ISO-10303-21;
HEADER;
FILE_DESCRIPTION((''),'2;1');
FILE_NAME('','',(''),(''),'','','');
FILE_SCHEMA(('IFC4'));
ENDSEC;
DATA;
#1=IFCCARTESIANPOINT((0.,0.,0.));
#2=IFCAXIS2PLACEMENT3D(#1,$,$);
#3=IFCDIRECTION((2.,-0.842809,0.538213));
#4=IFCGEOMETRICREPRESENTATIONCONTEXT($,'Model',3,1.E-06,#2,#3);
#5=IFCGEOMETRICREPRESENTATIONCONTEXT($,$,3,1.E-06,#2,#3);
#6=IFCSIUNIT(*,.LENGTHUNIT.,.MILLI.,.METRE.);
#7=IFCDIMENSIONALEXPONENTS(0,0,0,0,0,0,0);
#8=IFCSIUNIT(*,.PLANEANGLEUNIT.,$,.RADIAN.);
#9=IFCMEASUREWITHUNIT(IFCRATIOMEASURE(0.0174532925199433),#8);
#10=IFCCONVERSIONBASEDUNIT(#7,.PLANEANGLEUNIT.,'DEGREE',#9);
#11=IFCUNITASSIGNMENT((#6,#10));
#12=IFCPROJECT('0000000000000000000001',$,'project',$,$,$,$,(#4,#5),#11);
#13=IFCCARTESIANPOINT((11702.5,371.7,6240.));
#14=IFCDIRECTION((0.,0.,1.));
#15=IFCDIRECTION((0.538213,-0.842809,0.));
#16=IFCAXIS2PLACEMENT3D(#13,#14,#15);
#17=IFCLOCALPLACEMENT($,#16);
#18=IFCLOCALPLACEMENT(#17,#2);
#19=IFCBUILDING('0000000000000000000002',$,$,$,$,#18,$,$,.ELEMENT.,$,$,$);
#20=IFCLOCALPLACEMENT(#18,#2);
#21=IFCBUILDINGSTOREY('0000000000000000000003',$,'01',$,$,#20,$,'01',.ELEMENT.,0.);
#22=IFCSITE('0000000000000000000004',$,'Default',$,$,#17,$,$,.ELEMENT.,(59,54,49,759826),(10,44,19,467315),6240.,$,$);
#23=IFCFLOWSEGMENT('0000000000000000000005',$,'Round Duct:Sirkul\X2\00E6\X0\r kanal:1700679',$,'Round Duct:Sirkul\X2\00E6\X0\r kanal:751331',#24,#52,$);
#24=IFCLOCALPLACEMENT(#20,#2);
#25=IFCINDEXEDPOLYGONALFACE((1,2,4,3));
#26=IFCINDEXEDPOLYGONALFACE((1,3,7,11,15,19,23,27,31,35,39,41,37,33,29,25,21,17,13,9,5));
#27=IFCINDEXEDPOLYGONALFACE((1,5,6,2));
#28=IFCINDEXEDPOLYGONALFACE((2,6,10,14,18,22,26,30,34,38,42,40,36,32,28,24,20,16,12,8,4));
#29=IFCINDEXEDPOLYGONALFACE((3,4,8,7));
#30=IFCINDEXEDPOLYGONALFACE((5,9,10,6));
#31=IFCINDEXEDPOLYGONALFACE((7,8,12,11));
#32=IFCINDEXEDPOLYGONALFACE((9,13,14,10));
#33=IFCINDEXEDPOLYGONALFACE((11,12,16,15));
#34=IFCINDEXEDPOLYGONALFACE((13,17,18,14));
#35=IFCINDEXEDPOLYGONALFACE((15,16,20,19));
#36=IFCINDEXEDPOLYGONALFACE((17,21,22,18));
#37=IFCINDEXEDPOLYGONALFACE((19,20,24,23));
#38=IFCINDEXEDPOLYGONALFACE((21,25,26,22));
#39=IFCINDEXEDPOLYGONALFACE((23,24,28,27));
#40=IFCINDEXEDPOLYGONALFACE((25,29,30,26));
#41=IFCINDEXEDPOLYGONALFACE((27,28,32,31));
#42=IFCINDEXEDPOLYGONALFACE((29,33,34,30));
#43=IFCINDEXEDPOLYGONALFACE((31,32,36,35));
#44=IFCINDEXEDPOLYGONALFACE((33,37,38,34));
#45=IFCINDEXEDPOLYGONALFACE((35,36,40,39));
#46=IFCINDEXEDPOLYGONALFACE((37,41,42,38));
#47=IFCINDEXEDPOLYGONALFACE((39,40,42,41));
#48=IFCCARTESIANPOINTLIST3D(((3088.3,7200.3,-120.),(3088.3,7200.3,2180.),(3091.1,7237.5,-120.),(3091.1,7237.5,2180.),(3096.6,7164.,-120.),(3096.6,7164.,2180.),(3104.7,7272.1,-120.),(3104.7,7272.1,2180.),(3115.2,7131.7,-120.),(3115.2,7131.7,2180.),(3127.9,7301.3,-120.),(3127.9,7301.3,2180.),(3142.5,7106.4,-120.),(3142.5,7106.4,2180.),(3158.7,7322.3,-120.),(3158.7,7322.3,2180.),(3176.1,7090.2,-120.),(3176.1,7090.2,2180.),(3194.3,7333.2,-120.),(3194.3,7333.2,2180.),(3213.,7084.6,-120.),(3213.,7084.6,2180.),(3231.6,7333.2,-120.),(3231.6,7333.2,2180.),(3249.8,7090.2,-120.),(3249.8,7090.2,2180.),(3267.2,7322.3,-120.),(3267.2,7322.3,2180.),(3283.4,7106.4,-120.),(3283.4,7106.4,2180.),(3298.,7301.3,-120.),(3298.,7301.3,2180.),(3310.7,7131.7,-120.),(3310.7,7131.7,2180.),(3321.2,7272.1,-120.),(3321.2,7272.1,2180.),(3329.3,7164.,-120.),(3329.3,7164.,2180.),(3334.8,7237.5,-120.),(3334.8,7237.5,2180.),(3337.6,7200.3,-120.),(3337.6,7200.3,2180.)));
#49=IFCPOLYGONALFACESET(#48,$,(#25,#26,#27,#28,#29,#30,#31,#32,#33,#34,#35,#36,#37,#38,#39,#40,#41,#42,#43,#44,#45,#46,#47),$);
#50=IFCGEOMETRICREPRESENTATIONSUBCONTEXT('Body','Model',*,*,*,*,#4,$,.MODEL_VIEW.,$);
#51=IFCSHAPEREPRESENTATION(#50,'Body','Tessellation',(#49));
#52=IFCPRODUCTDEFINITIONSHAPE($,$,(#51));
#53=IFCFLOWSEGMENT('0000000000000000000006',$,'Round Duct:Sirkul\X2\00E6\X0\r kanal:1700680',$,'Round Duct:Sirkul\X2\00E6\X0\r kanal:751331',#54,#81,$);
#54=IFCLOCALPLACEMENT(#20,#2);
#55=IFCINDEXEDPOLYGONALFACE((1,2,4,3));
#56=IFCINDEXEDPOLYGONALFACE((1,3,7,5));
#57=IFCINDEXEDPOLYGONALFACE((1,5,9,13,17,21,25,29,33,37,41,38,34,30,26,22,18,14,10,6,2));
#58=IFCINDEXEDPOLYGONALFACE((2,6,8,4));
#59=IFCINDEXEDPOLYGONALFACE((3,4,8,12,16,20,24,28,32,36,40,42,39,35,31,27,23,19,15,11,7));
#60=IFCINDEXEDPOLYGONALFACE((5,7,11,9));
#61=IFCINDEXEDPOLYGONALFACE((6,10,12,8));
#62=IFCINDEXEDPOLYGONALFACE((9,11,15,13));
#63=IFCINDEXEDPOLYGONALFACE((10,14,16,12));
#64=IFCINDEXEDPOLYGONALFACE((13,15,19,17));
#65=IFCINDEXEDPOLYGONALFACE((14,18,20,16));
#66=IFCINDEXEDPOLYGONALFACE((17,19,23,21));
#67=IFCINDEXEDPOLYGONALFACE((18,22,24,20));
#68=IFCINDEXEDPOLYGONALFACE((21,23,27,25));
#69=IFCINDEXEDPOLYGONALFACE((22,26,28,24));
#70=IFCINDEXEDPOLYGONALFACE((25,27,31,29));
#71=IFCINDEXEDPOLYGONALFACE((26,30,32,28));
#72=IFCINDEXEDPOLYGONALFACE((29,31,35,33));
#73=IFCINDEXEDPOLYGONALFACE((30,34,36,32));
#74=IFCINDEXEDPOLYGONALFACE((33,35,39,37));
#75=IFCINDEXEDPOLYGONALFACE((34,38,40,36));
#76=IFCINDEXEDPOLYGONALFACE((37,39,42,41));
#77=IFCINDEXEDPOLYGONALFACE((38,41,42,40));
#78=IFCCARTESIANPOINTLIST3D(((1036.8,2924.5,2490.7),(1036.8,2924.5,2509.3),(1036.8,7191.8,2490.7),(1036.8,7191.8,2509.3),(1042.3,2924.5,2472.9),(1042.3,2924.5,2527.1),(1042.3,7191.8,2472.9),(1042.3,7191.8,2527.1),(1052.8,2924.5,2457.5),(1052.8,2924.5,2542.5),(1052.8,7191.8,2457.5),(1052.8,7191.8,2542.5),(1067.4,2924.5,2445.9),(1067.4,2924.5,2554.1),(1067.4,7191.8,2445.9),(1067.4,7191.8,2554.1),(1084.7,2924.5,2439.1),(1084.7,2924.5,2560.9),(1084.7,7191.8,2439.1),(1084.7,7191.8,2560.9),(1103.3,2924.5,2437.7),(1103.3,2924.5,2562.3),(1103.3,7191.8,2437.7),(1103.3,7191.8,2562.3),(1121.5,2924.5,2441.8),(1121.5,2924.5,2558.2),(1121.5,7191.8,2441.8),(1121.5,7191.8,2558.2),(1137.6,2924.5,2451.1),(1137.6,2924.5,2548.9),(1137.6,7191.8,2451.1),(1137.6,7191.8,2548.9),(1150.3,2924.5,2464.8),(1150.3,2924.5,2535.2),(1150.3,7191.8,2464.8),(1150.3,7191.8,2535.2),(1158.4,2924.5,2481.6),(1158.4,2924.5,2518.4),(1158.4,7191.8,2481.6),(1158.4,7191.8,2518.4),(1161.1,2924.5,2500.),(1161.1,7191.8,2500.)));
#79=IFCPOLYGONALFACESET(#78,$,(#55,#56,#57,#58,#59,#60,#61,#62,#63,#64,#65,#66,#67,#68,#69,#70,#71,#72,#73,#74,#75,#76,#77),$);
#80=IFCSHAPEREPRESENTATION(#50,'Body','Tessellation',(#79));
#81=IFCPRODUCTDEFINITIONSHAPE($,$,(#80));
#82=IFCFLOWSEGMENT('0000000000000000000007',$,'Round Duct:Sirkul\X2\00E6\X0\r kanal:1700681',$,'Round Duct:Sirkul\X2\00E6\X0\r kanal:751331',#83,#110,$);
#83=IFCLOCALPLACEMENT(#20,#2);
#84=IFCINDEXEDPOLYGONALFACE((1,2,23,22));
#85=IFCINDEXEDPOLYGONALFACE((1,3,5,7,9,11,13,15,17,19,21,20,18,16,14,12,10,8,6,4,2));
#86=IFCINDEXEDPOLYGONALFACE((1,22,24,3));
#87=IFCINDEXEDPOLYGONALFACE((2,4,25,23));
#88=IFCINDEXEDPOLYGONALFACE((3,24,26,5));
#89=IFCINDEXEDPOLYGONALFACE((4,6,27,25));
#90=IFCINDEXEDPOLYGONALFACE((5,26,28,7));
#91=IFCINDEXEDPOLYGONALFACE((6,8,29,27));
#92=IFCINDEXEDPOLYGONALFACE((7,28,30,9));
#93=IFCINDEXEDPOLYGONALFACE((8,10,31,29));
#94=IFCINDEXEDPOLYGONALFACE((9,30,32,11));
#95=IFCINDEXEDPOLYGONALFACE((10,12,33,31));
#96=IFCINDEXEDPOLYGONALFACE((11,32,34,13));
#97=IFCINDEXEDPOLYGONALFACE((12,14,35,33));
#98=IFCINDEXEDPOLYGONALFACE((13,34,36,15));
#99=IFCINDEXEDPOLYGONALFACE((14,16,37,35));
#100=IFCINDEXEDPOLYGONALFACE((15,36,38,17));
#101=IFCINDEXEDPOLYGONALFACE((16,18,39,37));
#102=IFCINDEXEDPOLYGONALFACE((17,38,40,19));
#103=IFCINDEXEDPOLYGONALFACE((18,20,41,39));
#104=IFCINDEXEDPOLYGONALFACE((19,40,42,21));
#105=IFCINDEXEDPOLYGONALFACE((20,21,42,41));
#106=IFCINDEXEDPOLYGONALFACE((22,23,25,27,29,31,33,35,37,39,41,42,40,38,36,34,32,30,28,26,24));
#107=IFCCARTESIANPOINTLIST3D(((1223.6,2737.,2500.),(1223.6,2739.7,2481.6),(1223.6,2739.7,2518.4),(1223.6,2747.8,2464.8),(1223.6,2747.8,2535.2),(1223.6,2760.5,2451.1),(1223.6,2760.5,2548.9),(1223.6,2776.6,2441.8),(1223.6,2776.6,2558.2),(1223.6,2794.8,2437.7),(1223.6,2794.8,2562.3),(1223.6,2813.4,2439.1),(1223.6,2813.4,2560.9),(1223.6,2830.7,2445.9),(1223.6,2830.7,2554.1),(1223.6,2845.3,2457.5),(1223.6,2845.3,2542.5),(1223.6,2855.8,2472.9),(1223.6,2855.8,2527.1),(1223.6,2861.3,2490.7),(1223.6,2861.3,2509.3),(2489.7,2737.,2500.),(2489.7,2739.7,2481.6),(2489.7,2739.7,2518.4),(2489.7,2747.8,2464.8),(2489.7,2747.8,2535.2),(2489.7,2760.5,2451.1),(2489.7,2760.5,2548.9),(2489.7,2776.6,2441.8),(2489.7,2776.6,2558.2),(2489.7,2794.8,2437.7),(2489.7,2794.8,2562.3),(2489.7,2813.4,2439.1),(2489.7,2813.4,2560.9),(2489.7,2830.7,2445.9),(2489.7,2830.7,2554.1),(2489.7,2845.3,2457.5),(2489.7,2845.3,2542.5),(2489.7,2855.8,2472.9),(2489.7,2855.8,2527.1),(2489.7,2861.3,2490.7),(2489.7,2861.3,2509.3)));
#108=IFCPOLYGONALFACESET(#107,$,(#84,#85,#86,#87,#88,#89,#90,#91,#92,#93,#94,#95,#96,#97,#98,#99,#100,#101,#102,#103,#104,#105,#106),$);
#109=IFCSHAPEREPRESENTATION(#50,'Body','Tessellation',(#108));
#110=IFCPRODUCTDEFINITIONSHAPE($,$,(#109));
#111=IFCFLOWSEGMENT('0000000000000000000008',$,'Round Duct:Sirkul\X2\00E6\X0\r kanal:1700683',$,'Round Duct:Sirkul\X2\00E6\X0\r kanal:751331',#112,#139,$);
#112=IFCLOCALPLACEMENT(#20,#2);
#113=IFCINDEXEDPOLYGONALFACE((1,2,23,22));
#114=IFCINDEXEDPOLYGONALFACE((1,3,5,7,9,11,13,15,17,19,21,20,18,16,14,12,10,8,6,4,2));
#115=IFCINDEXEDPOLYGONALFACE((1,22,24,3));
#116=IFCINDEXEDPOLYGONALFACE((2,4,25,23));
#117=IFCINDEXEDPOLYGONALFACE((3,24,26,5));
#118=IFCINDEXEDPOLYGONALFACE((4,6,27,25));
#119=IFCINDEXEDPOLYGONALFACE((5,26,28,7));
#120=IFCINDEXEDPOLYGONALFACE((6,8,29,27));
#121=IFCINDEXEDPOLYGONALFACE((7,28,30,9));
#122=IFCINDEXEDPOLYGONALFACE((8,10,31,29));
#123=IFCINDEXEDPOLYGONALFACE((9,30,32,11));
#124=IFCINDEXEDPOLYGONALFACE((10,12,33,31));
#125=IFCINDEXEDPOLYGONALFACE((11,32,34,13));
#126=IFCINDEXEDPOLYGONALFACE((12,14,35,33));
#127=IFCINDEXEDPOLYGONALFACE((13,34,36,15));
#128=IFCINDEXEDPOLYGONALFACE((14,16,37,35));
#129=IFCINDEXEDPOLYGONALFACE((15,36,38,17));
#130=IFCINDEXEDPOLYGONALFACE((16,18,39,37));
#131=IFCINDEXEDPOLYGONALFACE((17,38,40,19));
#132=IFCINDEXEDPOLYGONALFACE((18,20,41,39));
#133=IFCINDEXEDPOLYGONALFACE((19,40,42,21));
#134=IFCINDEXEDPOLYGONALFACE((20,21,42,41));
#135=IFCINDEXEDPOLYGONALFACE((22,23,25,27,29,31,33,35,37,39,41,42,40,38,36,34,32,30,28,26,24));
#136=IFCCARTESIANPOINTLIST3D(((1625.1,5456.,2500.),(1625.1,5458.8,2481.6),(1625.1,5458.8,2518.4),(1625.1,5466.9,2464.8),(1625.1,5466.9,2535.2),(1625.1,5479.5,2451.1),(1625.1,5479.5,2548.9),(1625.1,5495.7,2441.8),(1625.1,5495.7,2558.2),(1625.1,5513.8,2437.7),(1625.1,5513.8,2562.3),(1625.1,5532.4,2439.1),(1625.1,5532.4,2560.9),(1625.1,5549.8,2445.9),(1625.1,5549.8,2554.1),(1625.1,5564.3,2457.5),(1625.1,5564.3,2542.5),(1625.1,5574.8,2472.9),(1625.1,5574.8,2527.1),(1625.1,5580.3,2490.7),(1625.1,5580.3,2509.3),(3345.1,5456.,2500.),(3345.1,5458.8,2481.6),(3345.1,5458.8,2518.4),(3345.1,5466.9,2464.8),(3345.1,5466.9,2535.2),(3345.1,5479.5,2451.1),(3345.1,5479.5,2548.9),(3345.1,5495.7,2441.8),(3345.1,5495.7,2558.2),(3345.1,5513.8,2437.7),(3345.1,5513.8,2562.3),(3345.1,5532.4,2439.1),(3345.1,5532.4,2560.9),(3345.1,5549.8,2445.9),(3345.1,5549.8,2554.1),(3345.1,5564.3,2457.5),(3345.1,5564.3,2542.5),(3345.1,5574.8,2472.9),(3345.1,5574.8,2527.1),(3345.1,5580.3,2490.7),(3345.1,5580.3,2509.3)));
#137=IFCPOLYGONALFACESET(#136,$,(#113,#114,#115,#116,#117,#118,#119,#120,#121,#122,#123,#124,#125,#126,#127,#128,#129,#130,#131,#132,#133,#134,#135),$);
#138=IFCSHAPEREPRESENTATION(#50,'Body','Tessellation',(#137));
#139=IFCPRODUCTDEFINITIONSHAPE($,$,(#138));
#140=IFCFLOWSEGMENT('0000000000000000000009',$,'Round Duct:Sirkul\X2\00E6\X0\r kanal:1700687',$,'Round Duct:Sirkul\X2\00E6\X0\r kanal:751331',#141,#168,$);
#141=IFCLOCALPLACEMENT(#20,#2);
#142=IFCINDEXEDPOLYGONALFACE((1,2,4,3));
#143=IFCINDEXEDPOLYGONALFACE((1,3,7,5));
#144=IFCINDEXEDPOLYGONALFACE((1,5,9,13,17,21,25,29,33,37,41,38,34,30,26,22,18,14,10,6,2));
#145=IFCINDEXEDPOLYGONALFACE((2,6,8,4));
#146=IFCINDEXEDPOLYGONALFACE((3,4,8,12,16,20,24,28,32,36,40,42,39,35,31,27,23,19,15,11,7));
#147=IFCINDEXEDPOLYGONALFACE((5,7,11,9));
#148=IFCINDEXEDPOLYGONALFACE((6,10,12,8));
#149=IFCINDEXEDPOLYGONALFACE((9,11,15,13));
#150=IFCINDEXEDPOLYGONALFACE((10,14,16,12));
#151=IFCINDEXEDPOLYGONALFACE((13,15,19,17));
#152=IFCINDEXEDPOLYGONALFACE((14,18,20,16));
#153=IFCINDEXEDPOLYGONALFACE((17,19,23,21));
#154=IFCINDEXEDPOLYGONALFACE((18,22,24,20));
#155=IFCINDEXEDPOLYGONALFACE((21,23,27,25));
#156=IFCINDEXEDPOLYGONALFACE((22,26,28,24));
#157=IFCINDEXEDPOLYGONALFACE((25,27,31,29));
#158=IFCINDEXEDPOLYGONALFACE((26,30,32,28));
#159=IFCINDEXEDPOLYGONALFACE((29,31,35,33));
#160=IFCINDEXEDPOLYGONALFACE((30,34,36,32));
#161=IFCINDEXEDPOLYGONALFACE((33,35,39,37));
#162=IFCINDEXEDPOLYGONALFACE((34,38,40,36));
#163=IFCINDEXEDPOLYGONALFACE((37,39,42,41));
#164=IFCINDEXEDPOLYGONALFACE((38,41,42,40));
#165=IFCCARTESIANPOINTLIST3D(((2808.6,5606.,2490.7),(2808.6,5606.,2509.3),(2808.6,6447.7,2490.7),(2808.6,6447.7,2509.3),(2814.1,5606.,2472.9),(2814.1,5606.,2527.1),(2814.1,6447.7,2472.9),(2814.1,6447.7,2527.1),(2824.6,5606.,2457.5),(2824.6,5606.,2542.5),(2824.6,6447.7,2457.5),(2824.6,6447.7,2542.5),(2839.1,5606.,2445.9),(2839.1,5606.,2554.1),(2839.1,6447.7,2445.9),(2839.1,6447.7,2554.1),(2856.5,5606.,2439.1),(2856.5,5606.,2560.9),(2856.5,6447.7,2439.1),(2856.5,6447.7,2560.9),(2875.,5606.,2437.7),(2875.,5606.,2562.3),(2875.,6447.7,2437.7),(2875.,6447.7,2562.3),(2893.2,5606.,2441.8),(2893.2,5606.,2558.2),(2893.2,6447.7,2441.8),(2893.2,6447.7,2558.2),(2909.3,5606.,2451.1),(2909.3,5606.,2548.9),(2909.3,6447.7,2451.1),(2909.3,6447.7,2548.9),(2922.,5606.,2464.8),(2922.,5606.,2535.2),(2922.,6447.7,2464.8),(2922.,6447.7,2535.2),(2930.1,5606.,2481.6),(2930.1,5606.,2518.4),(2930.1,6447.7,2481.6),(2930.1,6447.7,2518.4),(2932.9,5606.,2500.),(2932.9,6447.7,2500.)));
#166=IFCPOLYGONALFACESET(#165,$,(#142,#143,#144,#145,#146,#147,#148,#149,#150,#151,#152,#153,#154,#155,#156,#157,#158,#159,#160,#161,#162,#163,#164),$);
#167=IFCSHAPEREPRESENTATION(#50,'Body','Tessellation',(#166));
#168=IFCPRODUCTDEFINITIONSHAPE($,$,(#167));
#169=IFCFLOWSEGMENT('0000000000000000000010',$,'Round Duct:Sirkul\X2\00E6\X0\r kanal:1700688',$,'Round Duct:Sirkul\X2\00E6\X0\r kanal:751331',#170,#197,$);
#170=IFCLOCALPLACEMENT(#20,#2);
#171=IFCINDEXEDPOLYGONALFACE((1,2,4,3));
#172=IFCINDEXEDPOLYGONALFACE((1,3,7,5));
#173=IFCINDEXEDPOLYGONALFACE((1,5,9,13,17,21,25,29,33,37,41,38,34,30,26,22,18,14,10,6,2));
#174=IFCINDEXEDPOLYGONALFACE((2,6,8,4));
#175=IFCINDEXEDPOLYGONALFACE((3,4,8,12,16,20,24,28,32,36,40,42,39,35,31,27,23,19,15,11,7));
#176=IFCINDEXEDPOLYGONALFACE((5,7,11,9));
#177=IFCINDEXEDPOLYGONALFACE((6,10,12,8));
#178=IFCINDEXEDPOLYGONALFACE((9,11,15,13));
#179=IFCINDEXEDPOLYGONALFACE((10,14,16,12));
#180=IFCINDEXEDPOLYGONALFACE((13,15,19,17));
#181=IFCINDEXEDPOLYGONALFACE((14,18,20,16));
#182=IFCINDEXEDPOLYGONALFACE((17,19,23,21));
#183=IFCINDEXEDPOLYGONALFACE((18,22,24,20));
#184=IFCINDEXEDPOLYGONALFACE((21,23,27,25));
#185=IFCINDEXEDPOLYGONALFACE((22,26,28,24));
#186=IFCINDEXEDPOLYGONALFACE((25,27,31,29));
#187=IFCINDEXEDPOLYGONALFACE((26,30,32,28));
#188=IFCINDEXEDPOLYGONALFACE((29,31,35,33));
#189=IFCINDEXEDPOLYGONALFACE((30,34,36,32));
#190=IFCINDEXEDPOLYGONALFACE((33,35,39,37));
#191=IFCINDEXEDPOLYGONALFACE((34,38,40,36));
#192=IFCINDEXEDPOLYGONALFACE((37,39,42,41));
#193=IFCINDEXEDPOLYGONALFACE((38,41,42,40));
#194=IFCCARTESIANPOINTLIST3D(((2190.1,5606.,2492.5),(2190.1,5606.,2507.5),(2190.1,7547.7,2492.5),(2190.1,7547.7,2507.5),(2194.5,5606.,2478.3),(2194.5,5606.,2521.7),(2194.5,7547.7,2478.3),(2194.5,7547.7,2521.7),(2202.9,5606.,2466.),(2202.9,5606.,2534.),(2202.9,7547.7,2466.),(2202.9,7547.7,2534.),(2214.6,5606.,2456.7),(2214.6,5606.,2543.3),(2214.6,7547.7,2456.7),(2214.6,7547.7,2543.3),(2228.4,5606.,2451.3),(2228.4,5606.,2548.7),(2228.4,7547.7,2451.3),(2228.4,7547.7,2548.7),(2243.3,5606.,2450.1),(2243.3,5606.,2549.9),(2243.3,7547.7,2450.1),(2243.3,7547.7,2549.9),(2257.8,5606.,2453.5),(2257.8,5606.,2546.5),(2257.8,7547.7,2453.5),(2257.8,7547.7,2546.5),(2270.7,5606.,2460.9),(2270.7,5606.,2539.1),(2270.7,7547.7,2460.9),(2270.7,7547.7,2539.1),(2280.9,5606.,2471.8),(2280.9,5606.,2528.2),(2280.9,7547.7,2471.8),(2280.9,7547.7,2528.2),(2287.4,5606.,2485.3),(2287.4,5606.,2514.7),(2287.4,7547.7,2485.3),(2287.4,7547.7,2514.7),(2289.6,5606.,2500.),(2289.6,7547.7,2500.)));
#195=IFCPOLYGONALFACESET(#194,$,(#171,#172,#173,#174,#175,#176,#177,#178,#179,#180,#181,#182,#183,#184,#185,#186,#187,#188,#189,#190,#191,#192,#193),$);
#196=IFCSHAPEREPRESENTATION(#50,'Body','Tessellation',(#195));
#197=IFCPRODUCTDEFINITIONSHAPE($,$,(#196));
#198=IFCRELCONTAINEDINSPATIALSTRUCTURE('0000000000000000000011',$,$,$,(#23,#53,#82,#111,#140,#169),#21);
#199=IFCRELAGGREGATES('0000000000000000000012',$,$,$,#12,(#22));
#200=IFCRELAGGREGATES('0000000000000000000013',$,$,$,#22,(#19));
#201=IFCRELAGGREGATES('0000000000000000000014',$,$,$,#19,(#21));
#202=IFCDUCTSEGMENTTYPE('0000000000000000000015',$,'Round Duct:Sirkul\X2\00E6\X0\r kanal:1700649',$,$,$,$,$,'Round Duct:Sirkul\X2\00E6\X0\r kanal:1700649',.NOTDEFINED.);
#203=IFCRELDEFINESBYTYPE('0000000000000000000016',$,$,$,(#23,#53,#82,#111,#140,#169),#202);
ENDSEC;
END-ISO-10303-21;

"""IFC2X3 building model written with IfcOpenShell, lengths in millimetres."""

from ifc_helpers import new_model, entity, si_unit, converted_unit, direction, frame, frame_2d, origin, origin_2d_with_axis, place, context, subcontext, project, spatial, circle, extrude, type_object, element, save


model = new_model("IFC2X3")

# Units and contexts
model_context = context("Model", 3, precision=1e-06, world=origin(), true_north=direction((2.0, -0.842809, 0.538213)))
context_of_model = context(None, 3, precision=1e-06, world=origin(), true_north=direction((2.0, -0.842809, 0.538213)))
body_context = subcontext(model_context, "Body", "Model", "MODEL_VIEW")
ifc_project = project(units=[si_unit("LENGTHUNIT", "METRE", prefix="MILLI"), converted_unit("PLANEANGLEUNIT", "DEGREE", entity("IfcRatioMeasure", 0.0174532925199433), si_unit("PLANEANGLEUNIT", "RADIAN"), dimensions=[0, 0, 0, 0, 0, 0, 0])], contexts=[model_context, context_of_model])

# Site, building, storey
site_placement = place(None, frame((11702.5, 371.7, 6240.0), z_axis=(0.0, 0.0, 1.0), x_axis=(0.538213, -0.842809, 0.0)))
site = spatial("IfcSite", under=ifc_project, at=site_placement, Name="Default", CompositionType="ELEMENT", RefLatitude=(59, 54, 49, 759826), RefLongitude=(10, 44, 19, 467315), RefElevation=6240.0)
building_placement = place(site_placement, origin())
building = spatial("IfcBuilding", under=site, at=building_placement, CompositionType="ELEMENT")
storey_placement = place(building_placement, origin())
storey = spatial("IfcBuildingStorey", under=building, at=storey_placement, Name="01", LongName="01", CompositionType="ELEMENT", Elevation=0.0)

# Flow segments
duct_segment_type = type_object("IfcDuctSegmentType", Name="Round Duct:Sirkulær kanal:1700649", ElementType="Round Duct:Sirkulær kanal:1700649", PredefinedType="NOTDEFINED")
flow_segment_1_placement = place(storey_placement, origin())
element("IfcFlowSegment", 1, at=flow_segment_1_placement, inside=storey, type_object=duct_segment_type, Name="Round Duct:Sirkulær kanal:1700679", ObjectType="Round Duct:Sirkulær kanal:751331", context=body_context, shape_type="SweptSolid", body=[
    extrude(circle(Radius=125.0, at=frame_2d((0.0, 0.0), x_axis=(1.0, 0.0))), frame((3213.0, 7209.6, -120.0), z_axis=(0.0, 0.0, 1.0), x_axis=(0.0, -1.0, 0.0)), (0.0, 0.0, 1.0), 2300.0),
])
flow_segment_2_placement = place(storey_placement, origin())
element("IfcFlowSegment", 2, at=flow_segment_2_placement, inside=storey, type_object=duct_segment_type, Name="Round Duct:Sirkulær kanal:1700680", ObjectType="Round Duct:Sirkulær kanal:751331", context=body_context, shape_type="SweptSolid", body=[
    extrude(circle(Radius=62.5, at=frame_2d((0.0, 0.0), x_axis=(1.0, 0.0))), frame((1098.6, 2924.5, 2500.0), z_axis=(0.0, 1.0, 0.0), x_axis=(1.0, 0.0, 0.0)), (0.0, 0.0, 1.0), 4267.3),
])
flow_segment_3_placement = place(storey_placement, origin())
element("IfcFlowSegment", 3, at=flow_segment_3_placement, inside=storey, type_object=duct_segment_type, Name="Round Duct:Sirkulær kanal:1700681", ObjectType="Round Duct:Sirkulær kanal:751331", context=body_context, shape_type="SweptSolid", body=[
    extrude(circle(Radius=62.5, at=frame_2d((0.0, 0.0), x_axis=(1.0, 0.0))), frame((1223.6, 2799.5, 2500.0), z_axis=(1.0, 0.0, 0.0), x_axis=(0.0, -1.0, 0.0)), (0.0, 0.0, 1.0), 1266.1),
])
flow_segment_4_placement = place(storey_placement, origin())
element("IfcFlowSegment", 4, at=flow_segment_4_placement, inside=storey, type_object=duct_segment_type, Name="Round Duct:Sirkulær kanal:1700683", ObjectType="Round Duct:Sirkulær kanal:751331", context=body_context, shape_type="SweptSolid", body=[
    extrude(circle(Radius=62.5, at=origin_2d_with_axis()), frame((1625.1, 5518.5, 2500.0), z_axis=(1.0, 0.0, 0.0), x_axis=(0.0, -1.0, 0.0)), (0.0, 0.0, 1.0), 1720.0),
])
flow_segment_5_placement = place(storey_placement, origin())
element("IfcFlowSegment", 5, at=flow_segment_5_placement, inside=storey, type_object=duct_segment_type, Name="Round Duct:Sirkulær kanal:1700687", ObjectType="Round Duct:Sirkulær kanal:751331", context=body_context, shape_type="SweptSolid", body=[
    extrude(circle(Radius=62.5, at=frame_2d((0.0, 0.0), x_axis=(1.0, 0.0))), frame((2870.4, 5606.0, 2500.0), z_axis=(0.0, 1.0, 0.0), x_axis=(1.0, 0.0, 0.0)), (0.0, 0.0, 1.0), 841.7),
])
flow_segment_6_placement = place(storey_placement, origin())
element("IfcFlowSegment", 6, at=flow_segment_6_placement, inside=storey, type_object=duct_segment_type, Name="Round Duct:Sirkulær kanal:1700688", ObjectType="Round Duct:Sirkulær kanal:751331", context=body_context, shape_type="SweptSolid", body=[
    extrude(circle(Radius=50.0, at=frame_2d((0.0, 0.0), x_axis=(1.0, 0.0))), frame((2239.6, 5606.0, 2500.0), z_axis=(0.0, 1.0, 0.0), x_axis=(1.0, 0.0, 0.0)), (0.0, 0.0, 1.0), 1941.7),
])

save(model, "model.ifc")
